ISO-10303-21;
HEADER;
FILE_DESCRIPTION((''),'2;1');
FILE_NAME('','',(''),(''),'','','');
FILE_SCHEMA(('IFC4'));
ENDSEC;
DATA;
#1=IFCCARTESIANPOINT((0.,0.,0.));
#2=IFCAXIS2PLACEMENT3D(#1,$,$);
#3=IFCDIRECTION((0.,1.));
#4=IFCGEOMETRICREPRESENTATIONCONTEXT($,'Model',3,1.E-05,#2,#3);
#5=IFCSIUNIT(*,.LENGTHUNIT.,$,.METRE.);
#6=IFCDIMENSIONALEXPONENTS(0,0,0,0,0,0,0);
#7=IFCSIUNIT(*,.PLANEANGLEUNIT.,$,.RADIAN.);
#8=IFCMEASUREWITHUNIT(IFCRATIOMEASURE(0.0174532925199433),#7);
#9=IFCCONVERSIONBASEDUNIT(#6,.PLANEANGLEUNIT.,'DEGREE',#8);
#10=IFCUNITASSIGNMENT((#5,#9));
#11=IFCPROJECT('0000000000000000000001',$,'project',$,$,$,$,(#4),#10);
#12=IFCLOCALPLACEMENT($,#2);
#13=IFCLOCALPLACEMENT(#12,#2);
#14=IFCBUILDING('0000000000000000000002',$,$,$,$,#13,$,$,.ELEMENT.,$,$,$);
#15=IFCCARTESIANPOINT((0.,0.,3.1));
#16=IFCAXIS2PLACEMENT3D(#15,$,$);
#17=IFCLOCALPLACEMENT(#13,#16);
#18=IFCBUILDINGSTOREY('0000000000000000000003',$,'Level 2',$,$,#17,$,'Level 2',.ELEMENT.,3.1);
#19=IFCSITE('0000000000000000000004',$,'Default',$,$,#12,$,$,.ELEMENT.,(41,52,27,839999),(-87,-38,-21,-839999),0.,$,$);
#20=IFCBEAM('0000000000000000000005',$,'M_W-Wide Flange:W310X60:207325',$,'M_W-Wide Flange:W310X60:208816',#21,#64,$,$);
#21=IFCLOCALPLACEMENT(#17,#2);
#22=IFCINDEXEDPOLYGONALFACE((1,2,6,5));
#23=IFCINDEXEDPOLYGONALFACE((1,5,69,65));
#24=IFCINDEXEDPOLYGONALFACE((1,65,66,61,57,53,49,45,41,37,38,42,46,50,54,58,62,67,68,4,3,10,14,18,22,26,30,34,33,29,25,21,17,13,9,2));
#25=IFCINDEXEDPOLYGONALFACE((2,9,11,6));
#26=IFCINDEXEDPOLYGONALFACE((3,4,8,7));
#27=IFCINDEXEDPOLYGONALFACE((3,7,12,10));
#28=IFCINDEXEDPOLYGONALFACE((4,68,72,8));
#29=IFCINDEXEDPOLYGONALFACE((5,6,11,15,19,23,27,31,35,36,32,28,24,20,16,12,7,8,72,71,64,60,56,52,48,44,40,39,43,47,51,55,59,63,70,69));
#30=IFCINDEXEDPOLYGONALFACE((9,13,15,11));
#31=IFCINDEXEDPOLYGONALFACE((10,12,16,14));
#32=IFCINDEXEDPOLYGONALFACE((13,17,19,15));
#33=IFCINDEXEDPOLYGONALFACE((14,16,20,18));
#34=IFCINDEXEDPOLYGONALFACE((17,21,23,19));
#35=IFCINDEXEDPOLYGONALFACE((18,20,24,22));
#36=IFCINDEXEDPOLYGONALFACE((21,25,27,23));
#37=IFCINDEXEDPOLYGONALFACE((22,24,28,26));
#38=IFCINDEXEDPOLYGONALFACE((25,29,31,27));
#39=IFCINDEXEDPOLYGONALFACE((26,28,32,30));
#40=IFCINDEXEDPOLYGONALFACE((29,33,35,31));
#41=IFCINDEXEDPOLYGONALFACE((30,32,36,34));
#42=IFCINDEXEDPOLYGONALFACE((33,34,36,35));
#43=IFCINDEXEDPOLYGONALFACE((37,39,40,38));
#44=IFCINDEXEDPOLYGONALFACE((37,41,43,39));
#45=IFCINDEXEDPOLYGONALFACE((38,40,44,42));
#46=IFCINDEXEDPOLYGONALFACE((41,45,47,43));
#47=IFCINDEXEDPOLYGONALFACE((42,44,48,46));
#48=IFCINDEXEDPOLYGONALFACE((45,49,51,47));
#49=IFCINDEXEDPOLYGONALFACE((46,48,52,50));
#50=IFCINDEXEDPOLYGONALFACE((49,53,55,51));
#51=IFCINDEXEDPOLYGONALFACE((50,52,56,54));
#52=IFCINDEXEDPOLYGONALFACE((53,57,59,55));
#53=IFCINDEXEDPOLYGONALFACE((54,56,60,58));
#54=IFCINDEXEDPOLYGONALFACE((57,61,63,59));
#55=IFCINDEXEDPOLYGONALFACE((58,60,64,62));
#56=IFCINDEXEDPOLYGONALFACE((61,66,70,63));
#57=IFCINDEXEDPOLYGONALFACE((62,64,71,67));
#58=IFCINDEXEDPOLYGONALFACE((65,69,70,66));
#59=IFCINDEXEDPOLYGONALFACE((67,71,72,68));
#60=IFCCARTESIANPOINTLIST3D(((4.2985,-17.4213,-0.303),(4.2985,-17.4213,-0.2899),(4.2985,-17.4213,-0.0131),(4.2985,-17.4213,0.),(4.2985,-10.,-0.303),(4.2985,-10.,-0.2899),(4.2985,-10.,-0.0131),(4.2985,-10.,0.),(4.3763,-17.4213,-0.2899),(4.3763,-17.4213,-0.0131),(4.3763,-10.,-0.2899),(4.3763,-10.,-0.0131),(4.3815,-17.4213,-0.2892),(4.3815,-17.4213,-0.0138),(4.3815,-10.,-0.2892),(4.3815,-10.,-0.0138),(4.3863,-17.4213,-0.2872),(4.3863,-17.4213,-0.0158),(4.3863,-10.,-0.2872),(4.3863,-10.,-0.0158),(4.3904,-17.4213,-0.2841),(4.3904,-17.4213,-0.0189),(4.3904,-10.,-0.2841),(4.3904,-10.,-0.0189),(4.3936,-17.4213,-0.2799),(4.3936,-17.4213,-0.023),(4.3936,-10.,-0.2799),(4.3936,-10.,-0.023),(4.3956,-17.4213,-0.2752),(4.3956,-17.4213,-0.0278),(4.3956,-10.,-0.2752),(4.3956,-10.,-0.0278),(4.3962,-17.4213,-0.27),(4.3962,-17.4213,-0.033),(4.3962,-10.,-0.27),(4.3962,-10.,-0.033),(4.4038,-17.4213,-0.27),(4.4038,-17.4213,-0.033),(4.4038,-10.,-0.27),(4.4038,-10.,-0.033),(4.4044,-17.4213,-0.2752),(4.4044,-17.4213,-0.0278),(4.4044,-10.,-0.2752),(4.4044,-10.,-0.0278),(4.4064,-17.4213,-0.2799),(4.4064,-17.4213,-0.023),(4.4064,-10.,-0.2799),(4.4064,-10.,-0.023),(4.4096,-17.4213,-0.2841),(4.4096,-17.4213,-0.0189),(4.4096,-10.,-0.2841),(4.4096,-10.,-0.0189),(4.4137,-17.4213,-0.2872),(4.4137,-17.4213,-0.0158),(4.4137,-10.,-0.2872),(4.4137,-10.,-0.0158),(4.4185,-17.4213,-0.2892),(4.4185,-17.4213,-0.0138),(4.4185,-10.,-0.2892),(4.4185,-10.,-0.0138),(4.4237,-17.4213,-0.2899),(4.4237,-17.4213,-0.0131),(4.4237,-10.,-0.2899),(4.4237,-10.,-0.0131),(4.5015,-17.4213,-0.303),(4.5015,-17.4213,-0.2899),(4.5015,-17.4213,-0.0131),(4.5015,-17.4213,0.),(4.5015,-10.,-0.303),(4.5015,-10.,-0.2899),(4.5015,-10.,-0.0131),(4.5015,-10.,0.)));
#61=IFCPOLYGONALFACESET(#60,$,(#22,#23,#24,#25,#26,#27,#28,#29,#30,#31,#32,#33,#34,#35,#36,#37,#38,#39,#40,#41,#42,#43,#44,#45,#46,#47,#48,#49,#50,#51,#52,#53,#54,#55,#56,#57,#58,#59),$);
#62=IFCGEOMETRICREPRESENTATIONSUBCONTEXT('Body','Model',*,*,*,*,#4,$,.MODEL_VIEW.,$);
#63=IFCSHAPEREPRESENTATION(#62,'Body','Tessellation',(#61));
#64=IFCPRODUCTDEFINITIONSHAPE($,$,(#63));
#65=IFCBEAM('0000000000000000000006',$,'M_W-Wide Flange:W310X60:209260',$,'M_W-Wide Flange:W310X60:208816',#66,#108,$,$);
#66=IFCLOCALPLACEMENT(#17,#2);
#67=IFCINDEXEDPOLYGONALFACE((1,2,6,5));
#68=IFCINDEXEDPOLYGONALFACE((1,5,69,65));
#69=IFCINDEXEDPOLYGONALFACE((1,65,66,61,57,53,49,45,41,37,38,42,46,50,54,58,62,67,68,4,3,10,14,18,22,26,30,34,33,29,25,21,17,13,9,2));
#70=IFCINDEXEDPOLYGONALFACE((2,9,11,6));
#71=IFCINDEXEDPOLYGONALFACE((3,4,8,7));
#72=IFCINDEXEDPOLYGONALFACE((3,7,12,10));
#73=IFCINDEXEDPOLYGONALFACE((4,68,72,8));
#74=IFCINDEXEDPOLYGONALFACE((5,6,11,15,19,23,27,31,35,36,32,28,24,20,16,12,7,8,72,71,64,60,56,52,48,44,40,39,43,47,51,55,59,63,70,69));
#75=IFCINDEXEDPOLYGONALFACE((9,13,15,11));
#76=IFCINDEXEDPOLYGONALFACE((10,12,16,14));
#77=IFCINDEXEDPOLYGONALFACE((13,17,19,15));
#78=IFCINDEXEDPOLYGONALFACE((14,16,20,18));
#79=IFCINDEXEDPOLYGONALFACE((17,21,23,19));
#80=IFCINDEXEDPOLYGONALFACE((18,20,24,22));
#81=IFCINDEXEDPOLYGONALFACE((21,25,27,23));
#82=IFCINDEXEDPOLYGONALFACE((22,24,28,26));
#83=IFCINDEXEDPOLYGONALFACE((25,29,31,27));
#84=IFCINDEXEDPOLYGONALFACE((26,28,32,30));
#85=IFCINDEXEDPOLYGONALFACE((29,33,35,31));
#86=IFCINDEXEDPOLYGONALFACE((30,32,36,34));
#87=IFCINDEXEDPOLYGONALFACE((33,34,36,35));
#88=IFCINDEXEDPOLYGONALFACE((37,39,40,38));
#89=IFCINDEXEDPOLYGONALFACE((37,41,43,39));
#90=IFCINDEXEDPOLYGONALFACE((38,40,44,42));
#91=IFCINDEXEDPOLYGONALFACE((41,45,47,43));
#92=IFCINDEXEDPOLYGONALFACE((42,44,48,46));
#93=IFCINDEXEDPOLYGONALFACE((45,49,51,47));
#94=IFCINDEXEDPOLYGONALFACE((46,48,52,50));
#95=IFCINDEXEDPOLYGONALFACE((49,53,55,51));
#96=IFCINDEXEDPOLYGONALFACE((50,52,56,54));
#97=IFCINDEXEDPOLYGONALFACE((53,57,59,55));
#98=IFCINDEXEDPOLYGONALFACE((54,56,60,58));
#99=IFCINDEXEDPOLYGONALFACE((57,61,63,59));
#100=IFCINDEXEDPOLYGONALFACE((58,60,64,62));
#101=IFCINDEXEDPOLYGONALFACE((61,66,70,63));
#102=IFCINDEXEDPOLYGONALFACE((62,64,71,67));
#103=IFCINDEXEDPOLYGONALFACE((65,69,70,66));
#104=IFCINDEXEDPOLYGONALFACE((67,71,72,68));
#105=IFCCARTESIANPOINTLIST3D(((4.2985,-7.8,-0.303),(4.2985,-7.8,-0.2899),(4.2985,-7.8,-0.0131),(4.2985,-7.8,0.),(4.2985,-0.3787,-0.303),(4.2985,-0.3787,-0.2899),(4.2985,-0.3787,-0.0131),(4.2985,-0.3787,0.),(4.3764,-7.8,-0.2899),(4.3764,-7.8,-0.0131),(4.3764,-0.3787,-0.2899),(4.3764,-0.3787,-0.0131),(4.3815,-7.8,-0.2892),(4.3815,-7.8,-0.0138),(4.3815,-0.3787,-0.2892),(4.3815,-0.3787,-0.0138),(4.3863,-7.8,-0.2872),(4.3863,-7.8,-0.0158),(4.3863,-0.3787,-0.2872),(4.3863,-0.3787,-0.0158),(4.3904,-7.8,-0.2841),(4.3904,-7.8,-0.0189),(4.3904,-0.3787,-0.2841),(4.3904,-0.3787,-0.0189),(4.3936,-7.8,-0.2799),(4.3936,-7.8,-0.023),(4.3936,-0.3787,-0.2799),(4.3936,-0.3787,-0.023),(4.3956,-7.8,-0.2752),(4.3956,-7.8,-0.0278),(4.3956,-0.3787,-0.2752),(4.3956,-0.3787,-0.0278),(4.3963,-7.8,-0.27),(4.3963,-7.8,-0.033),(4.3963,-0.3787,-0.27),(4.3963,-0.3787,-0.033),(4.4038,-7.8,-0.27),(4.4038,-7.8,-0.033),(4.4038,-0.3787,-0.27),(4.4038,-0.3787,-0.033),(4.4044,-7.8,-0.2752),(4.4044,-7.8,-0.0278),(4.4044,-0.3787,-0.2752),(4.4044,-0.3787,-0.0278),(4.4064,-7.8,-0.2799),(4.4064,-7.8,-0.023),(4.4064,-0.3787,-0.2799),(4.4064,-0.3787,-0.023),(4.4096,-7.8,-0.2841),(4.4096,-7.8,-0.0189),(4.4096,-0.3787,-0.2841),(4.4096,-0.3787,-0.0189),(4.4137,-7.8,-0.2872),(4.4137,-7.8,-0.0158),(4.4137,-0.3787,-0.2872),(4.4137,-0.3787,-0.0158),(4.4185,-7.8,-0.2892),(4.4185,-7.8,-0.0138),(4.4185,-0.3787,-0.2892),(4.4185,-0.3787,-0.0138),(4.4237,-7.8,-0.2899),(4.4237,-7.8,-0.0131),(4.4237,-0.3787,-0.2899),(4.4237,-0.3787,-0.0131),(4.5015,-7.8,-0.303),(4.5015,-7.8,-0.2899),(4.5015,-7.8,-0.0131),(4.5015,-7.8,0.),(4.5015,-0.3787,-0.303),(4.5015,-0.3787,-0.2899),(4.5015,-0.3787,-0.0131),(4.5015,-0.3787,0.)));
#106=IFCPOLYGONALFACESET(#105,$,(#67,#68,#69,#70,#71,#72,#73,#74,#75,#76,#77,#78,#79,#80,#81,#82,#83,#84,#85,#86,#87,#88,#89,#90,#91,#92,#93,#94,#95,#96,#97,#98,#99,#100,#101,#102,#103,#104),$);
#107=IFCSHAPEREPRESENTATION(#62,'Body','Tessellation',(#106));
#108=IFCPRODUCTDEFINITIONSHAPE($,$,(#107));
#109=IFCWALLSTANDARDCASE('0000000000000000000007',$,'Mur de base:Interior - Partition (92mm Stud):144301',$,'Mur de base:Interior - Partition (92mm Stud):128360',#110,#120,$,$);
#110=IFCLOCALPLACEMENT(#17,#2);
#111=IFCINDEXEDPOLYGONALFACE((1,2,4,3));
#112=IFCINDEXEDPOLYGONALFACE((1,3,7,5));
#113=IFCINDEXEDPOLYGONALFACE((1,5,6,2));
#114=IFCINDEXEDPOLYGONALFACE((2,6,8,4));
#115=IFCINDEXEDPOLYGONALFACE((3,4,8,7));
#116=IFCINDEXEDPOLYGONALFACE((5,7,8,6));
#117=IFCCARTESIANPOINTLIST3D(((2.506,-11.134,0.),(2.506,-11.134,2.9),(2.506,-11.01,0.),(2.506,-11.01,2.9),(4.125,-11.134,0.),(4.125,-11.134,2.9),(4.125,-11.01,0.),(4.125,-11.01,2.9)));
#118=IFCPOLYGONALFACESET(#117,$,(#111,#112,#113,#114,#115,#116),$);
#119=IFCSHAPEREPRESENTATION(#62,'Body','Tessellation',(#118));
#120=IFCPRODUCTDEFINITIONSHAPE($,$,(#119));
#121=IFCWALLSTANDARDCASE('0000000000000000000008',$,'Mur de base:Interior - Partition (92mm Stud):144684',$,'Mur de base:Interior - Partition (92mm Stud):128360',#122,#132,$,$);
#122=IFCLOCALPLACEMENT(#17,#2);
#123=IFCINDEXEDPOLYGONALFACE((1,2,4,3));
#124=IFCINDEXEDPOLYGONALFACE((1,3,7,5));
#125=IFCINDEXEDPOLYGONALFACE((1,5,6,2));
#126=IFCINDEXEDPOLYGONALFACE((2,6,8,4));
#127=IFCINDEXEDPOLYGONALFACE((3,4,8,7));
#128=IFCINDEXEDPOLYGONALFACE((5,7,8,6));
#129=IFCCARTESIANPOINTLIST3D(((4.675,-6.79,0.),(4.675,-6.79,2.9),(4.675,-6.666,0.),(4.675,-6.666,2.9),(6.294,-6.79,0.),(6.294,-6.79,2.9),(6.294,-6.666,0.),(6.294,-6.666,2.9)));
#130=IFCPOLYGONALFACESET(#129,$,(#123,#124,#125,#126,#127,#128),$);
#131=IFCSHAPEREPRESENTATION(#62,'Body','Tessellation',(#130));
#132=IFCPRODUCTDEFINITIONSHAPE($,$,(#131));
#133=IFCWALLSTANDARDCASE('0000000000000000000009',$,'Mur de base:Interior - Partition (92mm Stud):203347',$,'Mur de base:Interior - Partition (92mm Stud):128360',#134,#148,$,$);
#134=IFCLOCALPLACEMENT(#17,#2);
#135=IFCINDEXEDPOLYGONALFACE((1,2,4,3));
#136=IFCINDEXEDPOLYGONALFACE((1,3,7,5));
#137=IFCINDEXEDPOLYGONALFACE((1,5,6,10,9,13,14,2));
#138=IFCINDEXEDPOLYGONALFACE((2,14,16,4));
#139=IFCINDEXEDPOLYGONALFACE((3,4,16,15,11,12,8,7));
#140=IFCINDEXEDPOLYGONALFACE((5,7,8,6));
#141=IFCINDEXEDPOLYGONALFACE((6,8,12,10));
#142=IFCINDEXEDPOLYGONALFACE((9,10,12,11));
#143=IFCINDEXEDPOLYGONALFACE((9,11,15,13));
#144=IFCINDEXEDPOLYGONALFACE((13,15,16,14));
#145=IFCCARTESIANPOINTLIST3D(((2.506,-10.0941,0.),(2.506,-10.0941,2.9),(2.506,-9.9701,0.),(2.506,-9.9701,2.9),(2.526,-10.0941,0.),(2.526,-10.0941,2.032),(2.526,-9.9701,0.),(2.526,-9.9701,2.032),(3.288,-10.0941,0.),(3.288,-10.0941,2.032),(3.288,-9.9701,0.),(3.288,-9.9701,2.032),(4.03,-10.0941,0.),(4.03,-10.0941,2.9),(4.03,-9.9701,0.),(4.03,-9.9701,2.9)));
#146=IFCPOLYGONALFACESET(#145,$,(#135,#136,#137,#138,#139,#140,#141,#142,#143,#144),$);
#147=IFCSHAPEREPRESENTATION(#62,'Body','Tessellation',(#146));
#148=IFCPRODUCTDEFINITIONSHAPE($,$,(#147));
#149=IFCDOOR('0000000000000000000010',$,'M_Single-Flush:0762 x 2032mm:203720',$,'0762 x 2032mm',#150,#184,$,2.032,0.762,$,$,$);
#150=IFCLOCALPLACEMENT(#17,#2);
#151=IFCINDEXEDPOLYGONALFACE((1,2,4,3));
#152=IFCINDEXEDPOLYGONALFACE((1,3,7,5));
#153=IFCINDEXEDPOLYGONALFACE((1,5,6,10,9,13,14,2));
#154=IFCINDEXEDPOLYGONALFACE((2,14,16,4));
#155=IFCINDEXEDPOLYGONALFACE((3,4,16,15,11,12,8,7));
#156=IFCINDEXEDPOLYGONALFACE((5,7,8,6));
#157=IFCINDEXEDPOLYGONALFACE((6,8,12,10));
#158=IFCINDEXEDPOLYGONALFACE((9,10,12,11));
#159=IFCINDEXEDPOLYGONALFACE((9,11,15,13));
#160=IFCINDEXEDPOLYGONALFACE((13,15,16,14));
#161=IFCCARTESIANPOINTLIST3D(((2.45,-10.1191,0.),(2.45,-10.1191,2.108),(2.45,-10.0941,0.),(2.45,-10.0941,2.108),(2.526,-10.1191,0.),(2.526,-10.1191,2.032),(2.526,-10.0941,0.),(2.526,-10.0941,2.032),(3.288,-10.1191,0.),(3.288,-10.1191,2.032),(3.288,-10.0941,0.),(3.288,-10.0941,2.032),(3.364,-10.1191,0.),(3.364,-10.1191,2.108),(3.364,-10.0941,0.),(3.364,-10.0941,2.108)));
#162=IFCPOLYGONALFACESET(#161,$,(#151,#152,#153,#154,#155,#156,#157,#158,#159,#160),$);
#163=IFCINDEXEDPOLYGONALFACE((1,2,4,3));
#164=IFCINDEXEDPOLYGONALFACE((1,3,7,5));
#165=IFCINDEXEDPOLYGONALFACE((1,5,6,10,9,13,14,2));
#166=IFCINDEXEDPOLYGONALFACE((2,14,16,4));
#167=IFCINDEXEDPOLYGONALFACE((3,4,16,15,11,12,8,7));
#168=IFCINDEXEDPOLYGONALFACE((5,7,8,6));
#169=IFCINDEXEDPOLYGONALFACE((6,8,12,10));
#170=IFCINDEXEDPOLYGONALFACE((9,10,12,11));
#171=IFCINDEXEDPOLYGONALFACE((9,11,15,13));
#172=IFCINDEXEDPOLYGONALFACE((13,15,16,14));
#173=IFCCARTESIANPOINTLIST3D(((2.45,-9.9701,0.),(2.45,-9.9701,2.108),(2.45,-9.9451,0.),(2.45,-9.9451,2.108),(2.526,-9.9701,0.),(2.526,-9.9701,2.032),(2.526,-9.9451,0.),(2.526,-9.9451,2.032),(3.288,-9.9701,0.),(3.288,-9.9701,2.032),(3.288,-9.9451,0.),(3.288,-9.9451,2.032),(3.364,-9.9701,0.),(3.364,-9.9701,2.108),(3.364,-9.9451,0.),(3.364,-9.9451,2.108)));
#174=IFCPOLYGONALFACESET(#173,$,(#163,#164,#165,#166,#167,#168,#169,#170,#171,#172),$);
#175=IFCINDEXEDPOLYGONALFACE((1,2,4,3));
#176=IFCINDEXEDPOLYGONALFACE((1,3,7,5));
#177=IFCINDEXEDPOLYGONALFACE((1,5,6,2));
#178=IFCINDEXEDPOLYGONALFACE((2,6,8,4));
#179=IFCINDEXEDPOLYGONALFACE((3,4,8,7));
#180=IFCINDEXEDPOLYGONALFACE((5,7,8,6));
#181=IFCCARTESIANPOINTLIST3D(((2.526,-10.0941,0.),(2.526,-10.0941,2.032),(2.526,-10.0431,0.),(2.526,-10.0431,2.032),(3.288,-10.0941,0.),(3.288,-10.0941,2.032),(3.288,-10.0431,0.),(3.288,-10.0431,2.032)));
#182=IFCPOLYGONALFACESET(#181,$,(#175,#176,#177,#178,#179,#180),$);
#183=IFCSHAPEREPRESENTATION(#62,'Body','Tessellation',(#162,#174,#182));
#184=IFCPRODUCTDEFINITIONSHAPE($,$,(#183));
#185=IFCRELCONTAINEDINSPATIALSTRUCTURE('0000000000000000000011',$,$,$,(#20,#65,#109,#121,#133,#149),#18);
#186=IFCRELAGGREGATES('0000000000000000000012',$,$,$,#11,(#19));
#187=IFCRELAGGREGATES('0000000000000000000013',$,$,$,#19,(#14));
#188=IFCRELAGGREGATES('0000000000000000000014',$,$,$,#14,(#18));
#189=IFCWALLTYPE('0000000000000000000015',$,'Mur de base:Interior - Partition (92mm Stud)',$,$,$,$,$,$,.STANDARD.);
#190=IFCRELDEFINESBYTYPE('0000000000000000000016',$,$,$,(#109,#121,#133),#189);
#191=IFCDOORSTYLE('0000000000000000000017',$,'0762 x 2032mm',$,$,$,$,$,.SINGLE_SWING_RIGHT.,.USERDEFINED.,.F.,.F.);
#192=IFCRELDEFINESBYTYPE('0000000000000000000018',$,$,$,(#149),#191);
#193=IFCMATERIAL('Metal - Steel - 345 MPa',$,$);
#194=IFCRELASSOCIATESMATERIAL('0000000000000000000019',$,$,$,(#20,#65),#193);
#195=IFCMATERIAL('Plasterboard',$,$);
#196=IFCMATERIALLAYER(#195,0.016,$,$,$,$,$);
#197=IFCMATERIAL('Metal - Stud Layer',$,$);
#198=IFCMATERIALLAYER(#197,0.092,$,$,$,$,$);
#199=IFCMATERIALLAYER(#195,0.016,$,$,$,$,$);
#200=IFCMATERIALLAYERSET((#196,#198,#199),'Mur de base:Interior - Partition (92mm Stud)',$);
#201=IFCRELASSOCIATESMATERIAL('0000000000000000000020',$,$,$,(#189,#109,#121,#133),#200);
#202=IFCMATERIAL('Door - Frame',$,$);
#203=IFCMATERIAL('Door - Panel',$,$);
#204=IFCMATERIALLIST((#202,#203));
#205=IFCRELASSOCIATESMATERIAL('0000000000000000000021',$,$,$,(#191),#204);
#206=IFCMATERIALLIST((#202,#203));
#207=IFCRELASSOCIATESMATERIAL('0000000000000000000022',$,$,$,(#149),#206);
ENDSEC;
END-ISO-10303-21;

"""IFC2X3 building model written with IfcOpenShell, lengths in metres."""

from ifc_helpers import new_model, entity, si_unit, converted_unit, direction, frame, frame_2d, origin, origin_2d_with_axis, place, context, subcontext, project, spatial, polyline, rectangle, i_section, outline, extrude, source, transform, mapped, material, material_list, layer, layer_set, layer_usage, type_object, type_shapes, element, fill, save


model = new_model("IFC2X3")

# Units and contexts
model_context = context("Model", 3, precision=1e-05, world=origin(), true_north=direction((0.0, 1.0)))
body_context = subcontext(model_context, "Body", "Model", "MODEL_VIEW")
ifc_project = project(units=[si_unit("LENGTHUNIT", "METRE"), converted_unit("PLANEANGLEUNIT", "DEGREE", entity("IfcRatioMeasure", 0.0174532925199433), si_unit("PLANEANGLEUNIT", "RADIAN"), dimensions=[0, 0, 0, 0, 0, 0, 0])], contexts=[model_context])

# Site, building, storey
site_placement = place(None, origin())
site = spatial("IfcSite", under=ifc_project, at=site_placement, Name="Default", CompositionType="ELEMENT", RefLatitude=(41, 52, 27, 839999), RefLongitude=(-87, -38, -21, -839999), RefElevation=0.0)
building_placement = place(site_placement, origin())
building = spatial("IfcBuilding", under=site, at=building_placement, CompositionType="ELEMENT")
storey_placement = place(building_placement, frame((0.0, 0.0, 3.1)))
storey = spatial("IfcBuildingStorey", under=building, at=storey_placement, Name="Level 2", LongName="Level 2", CompositionType="ELEMENT", Elevation=3.1)

# Beams
ifc_material_1 = material(Name="Metal - Steel - 345 MPa")
beam_1_placement = place(storey_placement, frame((4.4, -10.0, 0.0), z_axis=(0.0, 0.0, 1.0), x_axis=(0.0, -1.0, 0.0)))
element("IfcBeam", 1, at=beam_1_placement, inside=storey, material=ifc_material_1, Name="M_W-Wide Flange:W310X60:207325", ObjectType="M_W-Wide Flange:W310X60:208816", context=body_context, shape_type="SweptSolid", body=[
    extrude(i_section(OverallWidth=0.203, OverallDepth=0.303, WebThickness=0.0075, FlangeThickness=0.0131, FilletRadius=0.0199, at=frame_2d((0.0, 0.0), x_axis=(0.0, 1.0))), frame((0.0, 0.0, -0.1515), z_axis=(1.0, 0.0, 0.0), x_axis=(0.0, 0.0, -1.0)), (0.0, 0.0, 1.0), 7.4213),
])
beam_2_placement = place(storey_placement, frame((4.4, -7.8, 0.0), z_axis=(0.0, 0.0, 1.0), x_axis=(0.0, 1.0, 0.0)))
element("IfcBeam", 2, at=beam_2_placement, inside=storey, material=ifc_material_1, Name="M_W-Wide Flange:W310X60:209260", ObjectType="M_W-Wide Flange:W310X60:208816", context=body_context, shape_type="SweptSolid", body=[
    extrude(i_section(OverallWidth=0.203, OverallDepth=0.303, WebThickness=0.0075, FlangeThickness=0.0131, FilletRadius=0.0199, at=frame_2d((0.0, 0.0), x_axis=(0.0, 1.0))), frame((0.0, 0.0, -0.1515), z_axis=(1.0, 0.0, 0.0), x_axis=(0.0, 0.0, -1.0)), (0.0, 0.0, 1.0), 7.4213),
])

# Walls
ifc_material_2 = material(Name="Plasterboard")
ifc_layer_1 = layer(ifc_material_2, 0.016)
ifc_material_3 = material(Name="Metal - Stud Layer")
ifc_layer_2 = layer(ifc_material_3, 0.092)
ifc_layer_3 = layer(ifc_material_2, 0.016)
ifc_layer_set_1 = layer_set([ifc_layer_1, ifc_layer_2, ifc_layer_3], Name="Mur de base:Interior - Partition (92mm Stud)")
ifc_layer_usage_1 = layer_usage(ifc_layer_set_1, "AXIS2", "NEGATIVE", 0.062)
wall_type_1 = type_object("IfcWallType", Name="Mur de base:Interior - Partition (92mm Stud)", PredefinedType="STANDARD", material=ifc_layer_set_1)
wall_1_placement = place(storey_placement, frame((4.125, -11.072, 0.0), z_axis=(0.0, 0.0, 1.0), x_axis=(-1.0, 0.0, 0.0)))
element("IfcWallStandardCase", 3, at=wall_1_placement, inside=storey, type_object=wall_type_1, material=ifc_layer_usage_1, Name="Mur de base:Interior - Partition (92mm Stud):144301", ObjectType="Mur de base:Interior - Partition (92mm Stud):128360", context=body_context, shape_type="SweptSolid", body=[
    extrude(rectangle(XDim=1.619, YDim=0.124, at=frame_2d((0.8095, 0.0), x_axis=(-1.0, 0.0))), origin(), (0.0, 0.0, 1.0), 2.9),
])
ifc_layer_usage_2 = layer_usage(ifc_layer_set_1, "AXIS2", "NEGATIVE", 0.062)
wall_2_placement = place(storey_placement, frame((4.675, -6.728, 0.0)))
element("IfcWallStandardCase", 4, at=wall_2_placement, inside=storey, type_object=wall_type_1, material=ifc_layer_usage_2, Name="Mur de base:Interior - Partition (92mm Stud):144684", ObjectType="Mur de base:Interior - Partition (92mm Stud):128360", context=body_context, shape_type="SweptSolid", body=[
    extrude(rectangle(XDim=1.619, YDim=0.124, at=frame_2d((0.8095, 0.0), x_axis=(-1.0, 0.0))), origin(), (0.0, 0.0, 1.0), 2.9),
])

# Wall, opening, door
ifc_layer_usage_3 = layer_usage(ifc_layer_set_1, "AXIS2", "NEGATIVE", 0.062)
wall_3_placement = place(storey_placement, frame((4.03, -10.0321, 0.0), z_axis=(0.0, 0.0, 1.0), x_axis=(-1.0, 0.0, 0.0)))
wall_3 = element("IfcWallStandardCase", 5, at=wall_3_placement, inside=storey, type_object=wall_type_1, material=ifc_layer_usage_3, Name="Mur de base:Interior - Partition (92mm Stud):203347", ObjectType="Mur de base:Interior - Partition (92mm Stud):128360", context=body_context, shape_type="SweptSolid", body=[
    extrude(rectangle(XDim=1.524, YDim=0.124, at=frame_2d((0.762, 0.0), x_axis=(-1.0, 0.0))), origin(), (0.0, 0.0, 1.0), 2.9),
])
opening_1_placement = place(wall_3_placement, frame((0.742, -0.062, 0.0)))
opening_1 = element("IfcOpeningElement", 6, at=opening_1_placement, cuts=wall_3, ObjectType="Opening", context=body_context, shape_type="SweptSolid", body=[
    extrude(rectangle(XDim=0.762, YDim=2.032, at=frame_2d((1.016, 0.381), x_axis=(0.0, 1.0))), frame((0.0, 0.0, 0.0), z_axis=(0.0, 1.0, 0.0), x_axis=(0.0, 0.0, 1.0)), (0.0, 0.0, 1.0), 0.124),
])
ifc_material_4 = material(Name="Door - Frame")
ifc_material_5 = material(Name="Door - Panel")
ifc_material_list_1 = material_list([ifc_material_4, ifc_material_5])
ifc_material_list_2 = material_list([ifc_material_4, ifc_material_5])
door_style = type_object("IfcDoorStyle", Name="0762 x 2032mm", ConstructionType="USERDEFINED", OperationType="SINGLE_SWING_RIGHT", ParameterTakesPrecedence=False, Sizeable=False, material=ifc_material_list_2)
shared_shape_1 = source(origin(), body_context, "Body", "SweptSolid", [
    extrude(outline(polyline([(-0.457, -1.073), (0.457, -1.073), (0.457, 1.035), (0.381, 1.035), (0.381, -0.997), (-0.381, -0.997), (-0.381, 1.035), (-0.457, 1.035), (-0.457, -1.073)])), frame((0.381, 0.124, 1.035), z_axis=(0.0, 1.0, 0.0), x_axis=(1.0, 0.0, 0.0)), (0.0, 0.0, 1.0), 0.025),
    extrude(outline(polyline([(-1.073, -0.457), (1.035, -0.457), (1.035, -0.381), (-0.997, -0.381), (-0.997, 0.381), (1.035, 0.381), (1.035, 0.457), (-1.073, 0.457), (-1.073, -0.457)])), frame((0.381, -0.025, 1.035), z_axis=(0.0, 1.0, 0.0), x_axis=(0.0, 0.0, -1.0)), (0.0, 0.0, 1.0), 0.025),
    extrude(rectangle(XDim=0.051, YDim=0.762, at=origin_2d_with_axis()), frame((0.381, 0.0985, 0.0), z_axis=(0.0, 0.0, 1.0), x_axis=(0.0, 1.0, 0.0)), (0.0, 0.0, 1.0), 2.032),
])
type_shapes(door_style, [shared_shape_1])
door_1_placement = place(opening_1_placement, origin())
door_1 = element("IfcDoor", 7, at=door_1_placement, inside=storey, type_object=door_style, material=ifc_material_list_1, Name="M_Single-Flush:0762 x 2032mm:203720", ObjectType="0762 x 2032mm", OverallHeight=2.032, OverallWidth=0.762, context=body_context, shape_type="MappedRepresentation", body=[
    mapped(shared_shape_1, transform((0.0, 0.0, 0.0), scale=1.0)),
])
fill(opening_1, door_1)

save(model, "model.ifc")
